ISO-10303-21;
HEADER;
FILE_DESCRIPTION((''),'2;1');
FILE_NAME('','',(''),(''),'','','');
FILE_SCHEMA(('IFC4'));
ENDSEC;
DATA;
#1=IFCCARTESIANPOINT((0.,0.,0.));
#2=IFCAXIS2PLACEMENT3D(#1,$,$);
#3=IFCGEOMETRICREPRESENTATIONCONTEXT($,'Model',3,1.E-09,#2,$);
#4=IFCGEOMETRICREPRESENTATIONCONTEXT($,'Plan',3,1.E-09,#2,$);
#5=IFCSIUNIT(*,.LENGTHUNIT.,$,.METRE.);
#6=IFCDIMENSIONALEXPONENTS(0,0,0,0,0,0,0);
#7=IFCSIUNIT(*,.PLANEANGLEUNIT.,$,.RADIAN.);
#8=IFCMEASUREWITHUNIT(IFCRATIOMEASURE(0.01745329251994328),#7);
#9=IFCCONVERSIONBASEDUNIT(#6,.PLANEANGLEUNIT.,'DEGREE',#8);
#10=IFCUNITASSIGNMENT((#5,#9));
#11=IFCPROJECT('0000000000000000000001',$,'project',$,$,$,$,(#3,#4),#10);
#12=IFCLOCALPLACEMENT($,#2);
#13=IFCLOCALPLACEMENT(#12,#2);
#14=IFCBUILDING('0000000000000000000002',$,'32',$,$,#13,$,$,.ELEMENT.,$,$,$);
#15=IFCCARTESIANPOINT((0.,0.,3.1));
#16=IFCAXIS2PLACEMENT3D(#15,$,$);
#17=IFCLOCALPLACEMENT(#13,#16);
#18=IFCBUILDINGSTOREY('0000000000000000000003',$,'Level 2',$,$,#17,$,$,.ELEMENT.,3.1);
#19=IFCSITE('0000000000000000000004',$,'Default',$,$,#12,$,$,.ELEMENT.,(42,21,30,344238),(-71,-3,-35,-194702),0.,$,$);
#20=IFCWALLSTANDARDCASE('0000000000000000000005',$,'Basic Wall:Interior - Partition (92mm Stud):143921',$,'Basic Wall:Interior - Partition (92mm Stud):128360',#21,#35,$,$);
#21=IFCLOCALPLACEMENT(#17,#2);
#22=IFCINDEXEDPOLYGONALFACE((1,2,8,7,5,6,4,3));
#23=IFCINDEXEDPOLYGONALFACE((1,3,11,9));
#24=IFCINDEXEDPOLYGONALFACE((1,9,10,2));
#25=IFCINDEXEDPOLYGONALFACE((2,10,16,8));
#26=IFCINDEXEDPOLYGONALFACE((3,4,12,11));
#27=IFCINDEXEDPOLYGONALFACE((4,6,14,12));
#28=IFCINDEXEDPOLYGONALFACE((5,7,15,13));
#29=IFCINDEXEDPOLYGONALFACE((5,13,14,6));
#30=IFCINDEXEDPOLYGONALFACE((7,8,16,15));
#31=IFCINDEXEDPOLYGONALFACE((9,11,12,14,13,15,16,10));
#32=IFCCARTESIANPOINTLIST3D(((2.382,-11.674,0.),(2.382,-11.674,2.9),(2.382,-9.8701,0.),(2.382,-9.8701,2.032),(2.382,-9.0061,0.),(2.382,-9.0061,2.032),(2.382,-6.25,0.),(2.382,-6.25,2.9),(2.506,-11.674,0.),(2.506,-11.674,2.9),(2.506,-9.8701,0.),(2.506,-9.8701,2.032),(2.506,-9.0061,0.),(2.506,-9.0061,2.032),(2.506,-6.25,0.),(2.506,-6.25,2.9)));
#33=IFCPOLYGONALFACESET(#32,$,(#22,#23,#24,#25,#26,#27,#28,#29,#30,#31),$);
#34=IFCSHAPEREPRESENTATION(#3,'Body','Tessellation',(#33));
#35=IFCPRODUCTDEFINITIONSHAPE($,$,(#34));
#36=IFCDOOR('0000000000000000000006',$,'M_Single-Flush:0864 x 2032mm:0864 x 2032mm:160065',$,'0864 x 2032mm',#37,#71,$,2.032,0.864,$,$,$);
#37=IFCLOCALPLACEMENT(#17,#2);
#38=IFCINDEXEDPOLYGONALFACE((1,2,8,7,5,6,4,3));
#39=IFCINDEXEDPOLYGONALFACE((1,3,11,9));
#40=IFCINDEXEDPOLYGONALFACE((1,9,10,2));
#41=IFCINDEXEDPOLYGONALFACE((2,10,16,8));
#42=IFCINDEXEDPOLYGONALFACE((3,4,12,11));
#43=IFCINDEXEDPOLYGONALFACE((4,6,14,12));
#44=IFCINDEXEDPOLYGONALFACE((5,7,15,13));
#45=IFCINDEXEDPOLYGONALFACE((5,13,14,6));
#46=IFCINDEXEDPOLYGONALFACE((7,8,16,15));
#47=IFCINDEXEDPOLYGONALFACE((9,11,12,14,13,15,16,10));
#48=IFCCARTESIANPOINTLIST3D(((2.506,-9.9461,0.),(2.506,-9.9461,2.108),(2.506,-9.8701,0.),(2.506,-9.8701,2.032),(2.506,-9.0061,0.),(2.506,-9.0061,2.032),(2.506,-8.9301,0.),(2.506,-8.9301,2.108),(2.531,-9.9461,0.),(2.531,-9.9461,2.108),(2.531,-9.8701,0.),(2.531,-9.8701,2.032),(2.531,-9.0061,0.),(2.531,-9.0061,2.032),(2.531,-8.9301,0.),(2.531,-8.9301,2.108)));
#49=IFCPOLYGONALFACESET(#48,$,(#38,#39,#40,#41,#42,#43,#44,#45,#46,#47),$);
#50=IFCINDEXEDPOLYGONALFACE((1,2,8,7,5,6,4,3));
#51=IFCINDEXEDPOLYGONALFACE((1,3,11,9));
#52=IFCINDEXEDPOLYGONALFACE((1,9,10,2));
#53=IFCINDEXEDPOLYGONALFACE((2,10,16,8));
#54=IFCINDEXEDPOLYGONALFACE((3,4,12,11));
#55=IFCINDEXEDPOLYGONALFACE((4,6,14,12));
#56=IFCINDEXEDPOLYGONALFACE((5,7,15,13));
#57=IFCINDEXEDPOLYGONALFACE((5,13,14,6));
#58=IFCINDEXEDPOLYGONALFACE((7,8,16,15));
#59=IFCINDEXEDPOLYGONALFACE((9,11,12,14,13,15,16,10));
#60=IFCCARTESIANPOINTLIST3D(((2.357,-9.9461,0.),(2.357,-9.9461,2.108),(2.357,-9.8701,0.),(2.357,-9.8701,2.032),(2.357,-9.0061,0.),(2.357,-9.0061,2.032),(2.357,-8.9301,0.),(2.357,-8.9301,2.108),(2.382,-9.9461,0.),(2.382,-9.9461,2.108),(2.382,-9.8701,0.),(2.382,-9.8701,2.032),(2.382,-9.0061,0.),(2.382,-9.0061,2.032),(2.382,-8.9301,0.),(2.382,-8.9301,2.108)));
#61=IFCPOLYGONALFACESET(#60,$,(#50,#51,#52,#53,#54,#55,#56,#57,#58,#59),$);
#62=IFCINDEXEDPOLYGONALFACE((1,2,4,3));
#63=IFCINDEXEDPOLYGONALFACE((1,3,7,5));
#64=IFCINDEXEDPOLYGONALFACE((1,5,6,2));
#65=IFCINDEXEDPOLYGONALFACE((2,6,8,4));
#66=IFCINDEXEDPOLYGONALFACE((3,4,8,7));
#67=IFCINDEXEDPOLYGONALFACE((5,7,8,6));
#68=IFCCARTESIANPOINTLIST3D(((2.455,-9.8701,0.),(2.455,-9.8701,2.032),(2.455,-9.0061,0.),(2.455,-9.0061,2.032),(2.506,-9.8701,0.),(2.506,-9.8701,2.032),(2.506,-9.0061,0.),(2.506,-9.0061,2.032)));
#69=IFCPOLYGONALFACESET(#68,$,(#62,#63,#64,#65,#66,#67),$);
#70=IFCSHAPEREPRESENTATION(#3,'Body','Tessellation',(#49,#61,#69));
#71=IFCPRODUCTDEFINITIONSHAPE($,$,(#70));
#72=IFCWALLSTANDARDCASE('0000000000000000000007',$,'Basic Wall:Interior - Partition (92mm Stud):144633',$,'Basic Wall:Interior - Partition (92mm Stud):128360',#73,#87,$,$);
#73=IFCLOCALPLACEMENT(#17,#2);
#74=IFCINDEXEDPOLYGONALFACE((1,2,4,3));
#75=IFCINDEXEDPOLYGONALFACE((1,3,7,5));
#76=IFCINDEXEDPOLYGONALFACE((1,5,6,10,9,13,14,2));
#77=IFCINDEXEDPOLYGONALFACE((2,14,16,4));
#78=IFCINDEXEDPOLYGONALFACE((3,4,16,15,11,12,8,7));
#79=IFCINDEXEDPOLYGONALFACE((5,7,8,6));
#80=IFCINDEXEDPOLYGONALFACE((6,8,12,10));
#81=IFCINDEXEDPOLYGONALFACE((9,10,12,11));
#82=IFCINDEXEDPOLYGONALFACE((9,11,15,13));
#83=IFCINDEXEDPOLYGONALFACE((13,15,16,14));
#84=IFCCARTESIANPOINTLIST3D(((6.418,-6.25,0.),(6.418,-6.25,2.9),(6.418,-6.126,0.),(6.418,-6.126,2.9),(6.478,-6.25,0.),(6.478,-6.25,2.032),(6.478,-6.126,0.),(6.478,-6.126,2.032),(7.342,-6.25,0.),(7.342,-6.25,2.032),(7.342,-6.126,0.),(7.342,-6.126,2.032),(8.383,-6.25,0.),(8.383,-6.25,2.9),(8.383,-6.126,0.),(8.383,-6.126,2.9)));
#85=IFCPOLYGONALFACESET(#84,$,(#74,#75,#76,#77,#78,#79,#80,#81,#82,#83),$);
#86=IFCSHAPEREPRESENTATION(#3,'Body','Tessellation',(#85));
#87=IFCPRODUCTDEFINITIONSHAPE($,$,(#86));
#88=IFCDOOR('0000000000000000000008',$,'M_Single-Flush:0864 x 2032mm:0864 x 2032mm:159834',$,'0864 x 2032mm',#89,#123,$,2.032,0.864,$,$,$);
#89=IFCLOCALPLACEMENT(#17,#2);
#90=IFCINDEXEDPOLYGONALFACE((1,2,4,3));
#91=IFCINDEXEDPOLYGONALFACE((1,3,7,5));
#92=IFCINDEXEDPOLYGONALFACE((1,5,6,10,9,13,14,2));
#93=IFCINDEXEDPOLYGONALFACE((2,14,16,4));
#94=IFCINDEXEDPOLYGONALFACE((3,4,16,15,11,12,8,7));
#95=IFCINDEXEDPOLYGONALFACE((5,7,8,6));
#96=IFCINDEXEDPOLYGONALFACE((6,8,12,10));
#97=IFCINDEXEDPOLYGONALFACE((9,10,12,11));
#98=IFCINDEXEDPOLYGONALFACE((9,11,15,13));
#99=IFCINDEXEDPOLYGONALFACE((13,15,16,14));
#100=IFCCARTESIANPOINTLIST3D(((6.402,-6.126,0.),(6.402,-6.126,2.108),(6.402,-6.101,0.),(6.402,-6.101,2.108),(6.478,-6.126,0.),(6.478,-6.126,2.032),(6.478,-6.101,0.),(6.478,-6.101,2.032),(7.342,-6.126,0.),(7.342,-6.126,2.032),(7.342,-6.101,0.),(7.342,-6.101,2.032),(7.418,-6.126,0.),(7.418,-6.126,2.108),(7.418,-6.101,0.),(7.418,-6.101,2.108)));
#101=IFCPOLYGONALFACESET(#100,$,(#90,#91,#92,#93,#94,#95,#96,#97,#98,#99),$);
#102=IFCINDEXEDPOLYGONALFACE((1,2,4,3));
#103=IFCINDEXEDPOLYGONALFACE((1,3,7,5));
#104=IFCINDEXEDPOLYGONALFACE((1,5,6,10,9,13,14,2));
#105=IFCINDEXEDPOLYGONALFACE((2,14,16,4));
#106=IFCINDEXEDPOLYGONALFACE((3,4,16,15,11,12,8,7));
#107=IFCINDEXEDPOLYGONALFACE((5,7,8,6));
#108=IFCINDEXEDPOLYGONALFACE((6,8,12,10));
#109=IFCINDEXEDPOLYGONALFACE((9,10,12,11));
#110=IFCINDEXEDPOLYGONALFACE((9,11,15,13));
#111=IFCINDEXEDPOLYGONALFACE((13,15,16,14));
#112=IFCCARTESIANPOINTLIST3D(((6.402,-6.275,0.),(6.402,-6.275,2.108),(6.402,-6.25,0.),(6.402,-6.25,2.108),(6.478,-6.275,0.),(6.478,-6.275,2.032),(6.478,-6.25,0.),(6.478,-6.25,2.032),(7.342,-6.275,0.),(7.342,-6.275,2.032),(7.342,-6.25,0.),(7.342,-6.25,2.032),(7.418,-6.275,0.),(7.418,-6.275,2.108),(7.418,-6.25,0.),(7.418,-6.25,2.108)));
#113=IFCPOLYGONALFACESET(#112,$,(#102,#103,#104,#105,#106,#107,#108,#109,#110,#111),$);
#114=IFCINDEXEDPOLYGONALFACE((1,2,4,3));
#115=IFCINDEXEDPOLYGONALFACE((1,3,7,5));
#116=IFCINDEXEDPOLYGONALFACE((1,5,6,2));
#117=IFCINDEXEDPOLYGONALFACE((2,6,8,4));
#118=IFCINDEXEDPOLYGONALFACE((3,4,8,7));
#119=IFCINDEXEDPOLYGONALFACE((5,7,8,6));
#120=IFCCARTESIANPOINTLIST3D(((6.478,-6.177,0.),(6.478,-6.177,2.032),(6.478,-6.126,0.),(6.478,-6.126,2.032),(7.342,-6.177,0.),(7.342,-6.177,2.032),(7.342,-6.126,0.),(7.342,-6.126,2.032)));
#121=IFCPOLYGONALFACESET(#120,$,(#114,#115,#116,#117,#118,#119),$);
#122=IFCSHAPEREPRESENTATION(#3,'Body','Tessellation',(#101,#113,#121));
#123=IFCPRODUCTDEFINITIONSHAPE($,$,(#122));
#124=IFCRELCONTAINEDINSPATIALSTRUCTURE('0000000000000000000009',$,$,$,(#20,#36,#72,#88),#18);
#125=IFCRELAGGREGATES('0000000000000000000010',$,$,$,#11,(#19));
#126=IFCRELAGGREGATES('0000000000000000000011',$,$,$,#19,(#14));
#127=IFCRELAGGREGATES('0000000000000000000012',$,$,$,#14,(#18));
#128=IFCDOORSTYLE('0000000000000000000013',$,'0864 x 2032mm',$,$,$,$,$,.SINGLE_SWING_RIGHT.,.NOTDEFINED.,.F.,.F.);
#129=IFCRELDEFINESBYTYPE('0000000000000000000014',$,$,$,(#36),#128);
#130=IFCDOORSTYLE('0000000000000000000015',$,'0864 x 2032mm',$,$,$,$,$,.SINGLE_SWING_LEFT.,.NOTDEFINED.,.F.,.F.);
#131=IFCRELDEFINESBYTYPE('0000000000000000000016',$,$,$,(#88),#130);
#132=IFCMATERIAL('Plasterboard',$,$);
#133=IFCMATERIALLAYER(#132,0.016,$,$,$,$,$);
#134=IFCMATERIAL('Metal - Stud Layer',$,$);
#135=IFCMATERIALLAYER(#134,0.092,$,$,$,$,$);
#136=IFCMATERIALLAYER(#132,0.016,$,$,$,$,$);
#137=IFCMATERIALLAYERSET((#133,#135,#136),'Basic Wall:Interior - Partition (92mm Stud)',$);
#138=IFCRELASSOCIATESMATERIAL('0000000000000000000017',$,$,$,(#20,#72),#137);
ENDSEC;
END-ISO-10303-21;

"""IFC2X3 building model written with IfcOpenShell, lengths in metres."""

from ifc_helpers import new_model, entity, si_unit, converted_unit, frame, frame_2d, origin, origin_2d_with_axis, place, context, project, spatial, polyline, rectangle, outline, extrude, source, transform, mapped, material, layer, layer_set, layer_usage, type_object, type_shapes, element, fill, save


model = new_model("IFC2X3")

# Units and contexts
model_context = context("Model", 3, precision=1e-09, world=origin())
plan_context = context("Plan", 3, precision=1e-09, world=origin())
ifc_project = project(units=[si_unit("LENGTHUNIT", "METRE"), converted_unit("PLANEANGLEUNIT", "DEGREE", entity("IfcRatioMeasure", 0.01745329251994328), si_unit("PLANEANGLEUNIT", "RADIAN"), dimensions=[0, 0, 0, 0, 0, 0, 0])], contexts=[model_context, plan_context])

# Site, building, storey
site_placement = place(None, origin())
site = spatial("IfcSite", under=ifc_project, at=site_placement, Name="Default", CompositionType="ELEMENT", RefLatitude=(42, 21, 30, 344238), RefLongitude=(-71, -3, -35, -194702), RefElevation=0.0)
building_placement = place(site_placement, origin())
building = spatial("IfcBuilding", under=site, at=building_placement, Name="32", CompositionType="ELEMENT")
storey_placement = place(building_placement, frame((0.0, 0.0, 3.1)))
storey = spatial("IfcBuildingStorey", under=building, at=storey_placement, Name="Level 2", CompositionType="ELEMENT", Elevation=3.1)

# Shared definitions
ifc_material_1 = material(Name="Metal - Stud Layer")
ifc_material_2 = material(Name="Plasterboard")

# Walls, openings, doors
ifc_layer_1 = layer(ifc_material_2, 0.016)
ifc_layer_2 = layer(ifc_material_1, 0.092)
ifc_layer_3 = layer(ifc_material_2, 0.016)
ifc_layer_set_1 = layer_set([ifc_layer_1, ifc_layer_2, ifc_layer_3], Name="Basic Wall:Interior - Partition (92mm Stud)")
ifc_layer_usage_1 = layer_usage(ifc_layer_set_1, "AXIS2", "NEGATIVE", 0.062)
wall_1_placement = place(storey_placement, frame((2.444, -6.25, 0.0), z_axis=(0.0, 0.0, 1.0), x_axis=(0.0, -1.0, 0.0)))
wall_1 = element("IfcWallStandardCase", 1, at=wall_1_placement, inside=storey, material=ifc_layer_usage_1, Name="Basic Wall:Interior - Partition (92mm Stud):143921", ObjectType="Basic Wall:Interior - Partition (92mm Stud):128360", context=model_context, shape_type="SweptSolid", body=[
    extrude(rectangle(XDim=5.424, YDim=0.124, at=frame_2d((2.712, 0.0), x_axis=(-1.0, 0.0))), origin(), (0.0, 0.0, 1.0), 2.9),
])
opening_1_placement = place(wall_1_placement, frame((2.7561, -0.062, 0.0)))
opening_1 = element("IfcOpeningElement", 2, at=opening_1_placement, cuts=wall_1, ObjectType="Opening", context=model_context, shape_type="SweptSolid", body=[
    extrude(rectangle(XDim=0.864, YDim=2.032, at=frame_2d((1.016, 0.432), x_axis=(0.0, 1.0))), frame((0.0, 0.0, 0.0), z_axis=(0.0, 1.0, 0.0), x_axis=(0.0, 0.0, 1.0)), (0.0, 0.0, 1.0), 0.124),
])
door_style_1 = type_object("IfcDoorStyle", Name="0864 x 2032mm", ConstructionType="NOTDEFINED", OperationType="SINGLE_SWING_RIGHT", ParameterTakesPrecedence=False, Sizeable=False)
shared_shape_1 = source(origin(), model_context, "Body", "SweptSolid", [
    extrude(outline(polyline([(-0.508, -1.073), (0.508, -1.073), (0.508, 1.035), (0.432, 1.035), (0.432, -0.997), (-0.432, -0.997), (-0.432, 1.035), (-0.508, 1.035), (-0.508, -1.073)])), frame((0.432, 0.124, 1.035), z_axis=(0.0, 1.0, 0.0), x_axis=(1.0, 0.0, 0.0)), (0.0, 0.0, 1.0), 0.025),
    extrude(outline(polyline([(-1.073, -0.508), (1.035, -0.508), (1.035, -0.432), (-0.997, -0.432), (-0.997, 0.432), (1.035, 0.432), (1.035, 0.508), (-1.073, 0.508), (-1.073, -0.508)])), frame((0.432, -0.025, 1.035), z_axis=(0.0, 1.0, 0.0), x_axis=(0.0, 0.0, -1.0)), (0.0, 0.0, 1.0), 0.025),
    extrude(rectangle(XDim=0.051, YDim=0.864, at=origin_2d_with_axis()), frame((0.432, 0.0985, 0.0), z_axis=(0.0, 0.0, 1.0), x_axis=(0.0, 1.0, 0.0)), (0.0, 0.0, 1.0), 2.032),
])
type_shapes(door_style_1, [shared_shape_1])
door_1_placement = place(opening_1_placement, origin())
door_1 = element("IfcDoor", 3, at=door_1_placement, inside=storey, type_object=door_style_1, Name="M_Single-Flush:0864 x 2032mm:0864 x 2032mm:160065", ObjectType="0864 x 2032mm", OverallHeight=2.032, OverallWidth=0.864, context=model_context, shape_type="MappedRepresentation", body=[
    mapped(shared_shape_1, transform((0.0, 0.0, 0.0), scale=1.0)),
])
fill(opening_1, door_1)
ifc_layer_usage_2 = layer_usage(ifc_layer_set_1, "AXIS2", "NEGATIVE", 0.062)
wall_2_placement = place(storey_placement, frame((6.418, -6.188, 0.0)))
wall_2 = element("IfcWallStandardCase", 4, at=wall_2_placement, inside=storey, material=ifc_layer_usage_2, Name="Basic Wall:Interior - Partition (92mm Stud):144633", ObjectType="Basic Wall:Interior - Partition (92mm Stud):128360", context=model_context, shape_type="SweptSolid", body=[
    extrude(rectangle(XDim=1.965, YDim=0.124, at=frame_2d((0.9825, 0.0), x_axis=(-1.0, 0.0))), origin(), (0.0, 0.0, 1.0), 2.9),
])
opening_2_placement = place(wall_2_placement, frame((0.06, -0.062, 0.0)))
opening_2 = element("IfcOpeningElement", 5, at=opening_2_placement, cuts=wall_2, ObjectType="Opening", context=model_context, shape_type="SweptSolid", body=[
    extrude(rectangle(XDim=0.864, YDim=2.032, at=frame_2d((1.016, 0.432), x_axis=(0.0, -1.0))), frame((0.0, 0.0, 0.0), z_axis=(0.0, 1.0, 0.0), x_axis=(0.0, 0.0, 1.0)), (0.0, 0.0, 1.0), 0.124),
])
door_style_2 = type_object("IfcDoorStyle", Name="0864 x 2032mm", ConstructionType="NOTDEFINED", OperationType="SINGLE_SWING_LEFT", ParameterTakesPrecedence=False, Sizeable=False)
shared_shape_2 = source(origin(), model_context, "Body", "SweptSolid", [
    extrude(outline(polyline([(-0.508, -1.073), (0.508, -1.073), (0.508, 1.035), (0.432, 1.035), (0.432, -0.997), (-0.432, -0.997), (-0.432, 1.035), (-0.508, 1.035), (-0.508, -1.073)])), frame((0.432, 0.149, 1.035), z_axis=(0.0, -1.0, 0.0), x_axis=(-1.0, 0.0, 0.0)), (0.0, 0.0, 1.0), 0.025),
    extrude(outline(polyline([(-1.073, -0.508), (1.035, -0.508), (1.035, -0.432), (-0.997, -0.432), (-0.997, 0.432), (1.035, 0.432), (1.035, 0.508), (-1.073, 0.508), (-1.073, -0.508)])), frame((0.432, 0.0, 1.035), z_axis=(0.0, -1.0, 0.0), x_axis=(0.0, 0.0, -1.0)), (0.0, 0.0, 1.0), 0.025),
    extrude(rectangle(XDim=0.864, YDim=0.051, at=origin_2d_with_axis()), frame((0.432, 0.0985, 0.0)), (0.0, 0.0, 1.0), 2.032),
])
type_shapes(door_style_2, [shared_shape_2])
door_2_placement = place(opening_2_placement, origin())
door_2 = element("IfcDoor", 6, at=door_2_placement, inside=storey, type_object=door_style_2, Name="M_Single-Flush:0864 x 2032mm:0864 x 2032mm:159834", ObjectType="0864 x 2032mm", OverallHeight=2.032, OverallWidth=0.864, context=model_context, shape_type="MappedRepresentation", body=[
    mapped(shared_shape_2, transform((0.0, 0.0, 0.0), scale=1.0)),
])
fill(opening_2, door_2)

save(model, "model.ifc")
